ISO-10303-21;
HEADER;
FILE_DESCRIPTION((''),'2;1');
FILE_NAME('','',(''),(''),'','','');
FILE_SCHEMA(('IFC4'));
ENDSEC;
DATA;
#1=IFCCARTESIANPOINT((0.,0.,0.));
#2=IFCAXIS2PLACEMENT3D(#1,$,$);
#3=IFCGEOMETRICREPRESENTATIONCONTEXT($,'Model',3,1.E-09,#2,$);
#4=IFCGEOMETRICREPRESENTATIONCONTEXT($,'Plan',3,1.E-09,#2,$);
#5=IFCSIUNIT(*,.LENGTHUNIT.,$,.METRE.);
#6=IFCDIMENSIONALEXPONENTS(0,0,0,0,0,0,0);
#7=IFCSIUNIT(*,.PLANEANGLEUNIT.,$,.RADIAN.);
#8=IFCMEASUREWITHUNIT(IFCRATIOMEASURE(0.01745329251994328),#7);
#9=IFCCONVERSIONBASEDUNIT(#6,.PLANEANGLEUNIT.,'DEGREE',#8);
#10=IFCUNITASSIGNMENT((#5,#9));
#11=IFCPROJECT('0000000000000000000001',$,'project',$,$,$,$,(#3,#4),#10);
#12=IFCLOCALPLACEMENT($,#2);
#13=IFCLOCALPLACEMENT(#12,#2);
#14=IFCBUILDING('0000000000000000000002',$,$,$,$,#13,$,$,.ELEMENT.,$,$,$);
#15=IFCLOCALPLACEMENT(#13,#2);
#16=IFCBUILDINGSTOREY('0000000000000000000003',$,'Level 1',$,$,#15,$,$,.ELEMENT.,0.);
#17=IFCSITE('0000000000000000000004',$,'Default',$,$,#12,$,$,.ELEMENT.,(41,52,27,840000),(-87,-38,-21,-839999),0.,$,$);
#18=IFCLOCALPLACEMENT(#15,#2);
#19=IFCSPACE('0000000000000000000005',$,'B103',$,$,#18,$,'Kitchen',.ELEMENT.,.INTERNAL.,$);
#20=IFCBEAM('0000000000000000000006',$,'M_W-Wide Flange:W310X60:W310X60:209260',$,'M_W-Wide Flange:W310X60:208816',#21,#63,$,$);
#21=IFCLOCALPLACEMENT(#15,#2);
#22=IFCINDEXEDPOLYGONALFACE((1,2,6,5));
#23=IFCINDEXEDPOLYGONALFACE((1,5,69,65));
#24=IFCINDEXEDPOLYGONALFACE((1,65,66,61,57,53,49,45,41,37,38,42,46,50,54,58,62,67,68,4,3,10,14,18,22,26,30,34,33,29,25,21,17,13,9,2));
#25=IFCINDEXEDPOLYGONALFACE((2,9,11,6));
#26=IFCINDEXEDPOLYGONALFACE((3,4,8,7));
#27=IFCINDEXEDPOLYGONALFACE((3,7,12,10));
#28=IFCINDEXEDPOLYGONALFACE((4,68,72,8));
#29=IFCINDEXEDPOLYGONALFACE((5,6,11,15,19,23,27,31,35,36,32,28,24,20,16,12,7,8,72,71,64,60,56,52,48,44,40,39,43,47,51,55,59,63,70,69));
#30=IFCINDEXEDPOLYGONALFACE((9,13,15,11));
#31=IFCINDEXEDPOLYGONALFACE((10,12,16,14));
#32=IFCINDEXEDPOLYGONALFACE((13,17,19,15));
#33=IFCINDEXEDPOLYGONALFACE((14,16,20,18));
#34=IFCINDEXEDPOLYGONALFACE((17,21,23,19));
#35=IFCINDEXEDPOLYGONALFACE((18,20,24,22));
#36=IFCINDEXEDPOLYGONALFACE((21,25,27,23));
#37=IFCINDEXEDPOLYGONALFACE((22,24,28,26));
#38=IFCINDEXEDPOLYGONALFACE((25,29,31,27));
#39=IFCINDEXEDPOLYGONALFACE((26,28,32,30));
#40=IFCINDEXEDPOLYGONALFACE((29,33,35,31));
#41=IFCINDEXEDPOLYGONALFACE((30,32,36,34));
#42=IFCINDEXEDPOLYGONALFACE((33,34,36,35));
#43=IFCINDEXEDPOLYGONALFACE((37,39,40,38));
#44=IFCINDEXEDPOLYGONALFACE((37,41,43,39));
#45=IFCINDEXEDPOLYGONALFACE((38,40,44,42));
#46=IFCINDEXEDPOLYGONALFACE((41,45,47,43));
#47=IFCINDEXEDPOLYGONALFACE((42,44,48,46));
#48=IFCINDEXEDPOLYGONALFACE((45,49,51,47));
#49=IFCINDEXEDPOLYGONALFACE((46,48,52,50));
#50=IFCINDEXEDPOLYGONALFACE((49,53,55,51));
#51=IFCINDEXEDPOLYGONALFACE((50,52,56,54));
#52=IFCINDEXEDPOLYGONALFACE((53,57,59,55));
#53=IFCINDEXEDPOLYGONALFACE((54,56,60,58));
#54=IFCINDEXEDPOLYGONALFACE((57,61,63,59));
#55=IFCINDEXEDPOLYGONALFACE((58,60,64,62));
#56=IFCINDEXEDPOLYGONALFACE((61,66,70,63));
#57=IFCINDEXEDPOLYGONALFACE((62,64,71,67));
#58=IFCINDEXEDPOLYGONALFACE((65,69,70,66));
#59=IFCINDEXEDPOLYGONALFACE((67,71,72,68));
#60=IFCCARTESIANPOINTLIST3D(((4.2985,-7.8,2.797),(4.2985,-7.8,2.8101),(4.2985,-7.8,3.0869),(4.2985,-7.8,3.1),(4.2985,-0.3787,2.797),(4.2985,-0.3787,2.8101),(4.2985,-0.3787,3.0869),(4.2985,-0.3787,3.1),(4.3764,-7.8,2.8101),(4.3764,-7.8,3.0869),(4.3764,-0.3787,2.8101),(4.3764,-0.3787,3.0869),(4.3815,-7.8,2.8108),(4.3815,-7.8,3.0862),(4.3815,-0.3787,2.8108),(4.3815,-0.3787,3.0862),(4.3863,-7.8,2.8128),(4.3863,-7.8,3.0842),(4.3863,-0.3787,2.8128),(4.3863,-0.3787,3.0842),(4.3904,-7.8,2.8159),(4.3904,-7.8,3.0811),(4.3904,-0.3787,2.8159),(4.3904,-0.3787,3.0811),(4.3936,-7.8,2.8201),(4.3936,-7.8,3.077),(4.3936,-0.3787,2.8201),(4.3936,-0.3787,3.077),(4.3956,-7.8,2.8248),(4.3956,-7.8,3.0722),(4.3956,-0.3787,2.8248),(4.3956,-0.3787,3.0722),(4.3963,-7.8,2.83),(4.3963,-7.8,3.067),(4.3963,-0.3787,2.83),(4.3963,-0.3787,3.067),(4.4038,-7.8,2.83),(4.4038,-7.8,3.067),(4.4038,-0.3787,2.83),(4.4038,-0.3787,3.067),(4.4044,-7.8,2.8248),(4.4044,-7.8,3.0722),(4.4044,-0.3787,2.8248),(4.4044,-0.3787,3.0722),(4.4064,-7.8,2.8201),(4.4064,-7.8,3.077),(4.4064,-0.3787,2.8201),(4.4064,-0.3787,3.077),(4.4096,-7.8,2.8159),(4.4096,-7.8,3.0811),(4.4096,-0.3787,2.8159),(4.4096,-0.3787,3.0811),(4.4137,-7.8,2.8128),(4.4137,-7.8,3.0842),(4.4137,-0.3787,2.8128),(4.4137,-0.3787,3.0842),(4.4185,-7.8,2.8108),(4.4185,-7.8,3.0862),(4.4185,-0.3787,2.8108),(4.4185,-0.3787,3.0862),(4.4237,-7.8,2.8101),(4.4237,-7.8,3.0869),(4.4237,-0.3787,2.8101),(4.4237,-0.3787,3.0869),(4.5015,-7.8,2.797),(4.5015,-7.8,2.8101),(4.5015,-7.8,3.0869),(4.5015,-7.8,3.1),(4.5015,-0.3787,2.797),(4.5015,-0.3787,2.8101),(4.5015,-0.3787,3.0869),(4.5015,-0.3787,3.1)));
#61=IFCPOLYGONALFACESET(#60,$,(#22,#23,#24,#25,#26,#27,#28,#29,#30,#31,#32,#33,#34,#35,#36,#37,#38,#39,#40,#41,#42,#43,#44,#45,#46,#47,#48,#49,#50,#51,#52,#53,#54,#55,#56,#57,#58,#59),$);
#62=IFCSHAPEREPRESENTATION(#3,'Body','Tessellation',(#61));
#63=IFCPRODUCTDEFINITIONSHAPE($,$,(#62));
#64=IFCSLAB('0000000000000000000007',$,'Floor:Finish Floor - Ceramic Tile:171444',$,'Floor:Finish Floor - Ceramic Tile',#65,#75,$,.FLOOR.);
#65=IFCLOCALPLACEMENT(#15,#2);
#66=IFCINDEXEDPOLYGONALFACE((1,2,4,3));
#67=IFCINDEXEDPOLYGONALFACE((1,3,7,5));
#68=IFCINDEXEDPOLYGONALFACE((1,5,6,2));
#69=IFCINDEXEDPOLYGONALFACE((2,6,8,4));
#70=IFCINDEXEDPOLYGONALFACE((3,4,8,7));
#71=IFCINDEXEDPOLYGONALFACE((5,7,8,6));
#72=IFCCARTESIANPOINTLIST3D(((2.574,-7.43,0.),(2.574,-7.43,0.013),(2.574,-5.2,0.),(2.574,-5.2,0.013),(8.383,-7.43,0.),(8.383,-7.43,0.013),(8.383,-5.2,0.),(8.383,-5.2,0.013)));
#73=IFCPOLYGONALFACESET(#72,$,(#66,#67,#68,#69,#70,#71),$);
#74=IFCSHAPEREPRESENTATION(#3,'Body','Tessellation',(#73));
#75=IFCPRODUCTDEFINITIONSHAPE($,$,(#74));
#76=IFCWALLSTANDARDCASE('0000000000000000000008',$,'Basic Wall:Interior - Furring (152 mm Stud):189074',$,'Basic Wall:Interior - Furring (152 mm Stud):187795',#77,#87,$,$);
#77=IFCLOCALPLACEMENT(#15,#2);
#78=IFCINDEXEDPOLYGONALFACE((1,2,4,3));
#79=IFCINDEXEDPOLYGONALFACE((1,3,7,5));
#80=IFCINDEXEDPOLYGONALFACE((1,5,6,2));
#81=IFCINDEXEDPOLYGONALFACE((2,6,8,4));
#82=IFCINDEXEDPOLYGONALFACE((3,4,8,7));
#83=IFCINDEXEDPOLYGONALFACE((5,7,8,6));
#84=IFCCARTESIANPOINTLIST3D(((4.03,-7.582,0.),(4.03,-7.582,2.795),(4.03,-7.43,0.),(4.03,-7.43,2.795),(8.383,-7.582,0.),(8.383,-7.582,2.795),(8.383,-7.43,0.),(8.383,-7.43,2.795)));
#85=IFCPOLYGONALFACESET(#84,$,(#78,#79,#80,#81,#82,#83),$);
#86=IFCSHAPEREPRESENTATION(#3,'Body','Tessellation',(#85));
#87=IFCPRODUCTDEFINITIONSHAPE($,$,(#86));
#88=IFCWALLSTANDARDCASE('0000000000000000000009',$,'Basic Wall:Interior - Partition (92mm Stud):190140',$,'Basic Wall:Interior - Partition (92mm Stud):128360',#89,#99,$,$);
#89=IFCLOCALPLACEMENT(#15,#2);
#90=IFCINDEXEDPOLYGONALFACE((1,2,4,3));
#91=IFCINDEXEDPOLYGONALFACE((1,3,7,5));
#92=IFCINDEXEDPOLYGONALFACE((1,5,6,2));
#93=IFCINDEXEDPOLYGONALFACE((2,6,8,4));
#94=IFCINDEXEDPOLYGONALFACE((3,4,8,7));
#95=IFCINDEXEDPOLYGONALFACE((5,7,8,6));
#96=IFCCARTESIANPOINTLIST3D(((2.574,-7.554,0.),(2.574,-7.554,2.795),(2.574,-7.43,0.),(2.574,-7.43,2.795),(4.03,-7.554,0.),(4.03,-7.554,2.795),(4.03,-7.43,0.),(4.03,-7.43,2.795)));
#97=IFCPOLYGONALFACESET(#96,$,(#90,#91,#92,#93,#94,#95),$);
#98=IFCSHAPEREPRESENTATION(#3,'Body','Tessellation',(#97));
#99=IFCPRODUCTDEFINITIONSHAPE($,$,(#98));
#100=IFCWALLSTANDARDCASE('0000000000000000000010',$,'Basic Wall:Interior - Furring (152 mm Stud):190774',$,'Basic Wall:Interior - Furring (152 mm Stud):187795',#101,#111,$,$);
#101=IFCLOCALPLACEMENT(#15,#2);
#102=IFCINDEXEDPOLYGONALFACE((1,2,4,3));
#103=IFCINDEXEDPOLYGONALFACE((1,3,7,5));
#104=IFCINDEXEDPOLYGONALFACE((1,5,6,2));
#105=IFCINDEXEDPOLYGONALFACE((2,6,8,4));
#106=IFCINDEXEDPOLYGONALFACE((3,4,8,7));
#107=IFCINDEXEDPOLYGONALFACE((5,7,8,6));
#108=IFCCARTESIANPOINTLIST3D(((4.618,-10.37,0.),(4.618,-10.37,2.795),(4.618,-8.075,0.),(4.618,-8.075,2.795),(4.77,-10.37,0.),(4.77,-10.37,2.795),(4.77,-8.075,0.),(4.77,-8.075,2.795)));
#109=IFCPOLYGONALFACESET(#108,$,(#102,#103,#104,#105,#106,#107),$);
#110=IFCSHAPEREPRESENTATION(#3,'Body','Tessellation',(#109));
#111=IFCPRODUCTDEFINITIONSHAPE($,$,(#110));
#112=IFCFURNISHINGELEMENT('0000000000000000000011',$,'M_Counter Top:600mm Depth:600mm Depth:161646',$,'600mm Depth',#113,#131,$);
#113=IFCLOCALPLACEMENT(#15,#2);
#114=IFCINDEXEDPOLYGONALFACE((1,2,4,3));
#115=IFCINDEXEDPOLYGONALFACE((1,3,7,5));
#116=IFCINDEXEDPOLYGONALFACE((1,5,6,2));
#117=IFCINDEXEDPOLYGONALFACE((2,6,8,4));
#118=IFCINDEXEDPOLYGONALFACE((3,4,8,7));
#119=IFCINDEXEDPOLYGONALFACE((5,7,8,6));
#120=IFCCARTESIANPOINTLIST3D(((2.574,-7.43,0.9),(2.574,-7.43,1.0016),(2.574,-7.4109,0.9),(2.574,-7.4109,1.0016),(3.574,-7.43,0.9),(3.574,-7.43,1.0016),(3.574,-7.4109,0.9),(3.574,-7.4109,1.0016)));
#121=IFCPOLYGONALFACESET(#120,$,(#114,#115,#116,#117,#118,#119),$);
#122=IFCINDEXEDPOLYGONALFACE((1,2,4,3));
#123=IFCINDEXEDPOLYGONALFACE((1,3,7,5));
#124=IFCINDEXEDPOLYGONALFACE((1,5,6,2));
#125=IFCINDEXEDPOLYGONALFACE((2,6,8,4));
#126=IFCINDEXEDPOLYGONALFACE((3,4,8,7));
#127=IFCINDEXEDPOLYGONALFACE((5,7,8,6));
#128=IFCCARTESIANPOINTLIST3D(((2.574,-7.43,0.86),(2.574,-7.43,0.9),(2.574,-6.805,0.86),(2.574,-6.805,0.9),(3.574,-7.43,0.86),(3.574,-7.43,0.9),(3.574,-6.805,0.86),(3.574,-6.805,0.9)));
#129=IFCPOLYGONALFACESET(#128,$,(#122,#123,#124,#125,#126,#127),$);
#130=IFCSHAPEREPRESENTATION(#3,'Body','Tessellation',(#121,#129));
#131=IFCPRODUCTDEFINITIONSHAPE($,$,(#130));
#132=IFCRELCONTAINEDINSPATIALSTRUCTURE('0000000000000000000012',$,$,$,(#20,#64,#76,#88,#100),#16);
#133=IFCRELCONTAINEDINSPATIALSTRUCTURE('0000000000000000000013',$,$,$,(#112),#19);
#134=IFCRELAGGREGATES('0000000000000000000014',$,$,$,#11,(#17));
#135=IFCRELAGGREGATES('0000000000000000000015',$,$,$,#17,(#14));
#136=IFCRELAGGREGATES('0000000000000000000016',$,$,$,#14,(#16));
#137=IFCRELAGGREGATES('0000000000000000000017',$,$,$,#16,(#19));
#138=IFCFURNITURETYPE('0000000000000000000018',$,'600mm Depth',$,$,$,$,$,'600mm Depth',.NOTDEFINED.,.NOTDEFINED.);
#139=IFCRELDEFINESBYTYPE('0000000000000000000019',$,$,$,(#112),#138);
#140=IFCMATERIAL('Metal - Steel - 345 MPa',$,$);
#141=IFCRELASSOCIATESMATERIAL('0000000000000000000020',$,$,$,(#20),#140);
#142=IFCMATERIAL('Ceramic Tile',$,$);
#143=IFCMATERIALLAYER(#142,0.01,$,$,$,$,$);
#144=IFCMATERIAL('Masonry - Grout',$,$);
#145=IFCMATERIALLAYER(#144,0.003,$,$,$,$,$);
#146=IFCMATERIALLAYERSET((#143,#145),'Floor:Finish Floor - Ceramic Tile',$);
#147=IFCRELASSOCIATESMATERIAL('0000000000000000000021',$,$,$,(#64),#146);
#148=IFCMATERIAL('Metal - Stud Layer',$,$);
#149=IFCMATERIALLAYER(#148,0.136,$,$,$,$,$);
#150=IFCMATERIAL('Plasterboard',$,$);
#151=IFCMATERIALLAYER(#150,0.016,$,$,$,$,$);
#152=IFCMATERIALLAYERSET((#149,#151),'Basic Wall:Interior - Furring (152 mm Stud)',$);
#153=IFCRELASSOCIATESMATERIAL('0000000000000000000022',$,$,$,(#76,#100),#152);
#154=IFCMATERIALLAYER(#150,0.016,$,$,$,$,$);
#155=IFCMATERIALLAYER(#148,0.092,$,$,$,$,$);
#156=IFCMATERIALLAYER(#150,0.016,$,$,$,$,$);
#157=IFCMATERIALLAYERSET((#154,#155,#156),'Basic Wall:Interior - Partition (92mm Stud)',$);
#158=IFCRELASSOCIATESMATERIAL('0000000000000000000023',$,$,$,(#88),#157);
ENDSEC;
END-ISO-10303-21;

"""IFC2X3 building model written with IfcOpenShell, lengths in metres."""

from ifc_helpers import new_model, entity, si_unit, converted_unit, frame, frame_2d, origin, origin_2d_with_axis, place, context, project, spatial, polyline, circle_curve, parameter, trimmed, segment, composite_curve, rectangle, outline, extrude, clip, bounded_halfspace, source, transform, mapped, material, layer, layer_set, layer_usage, type_object, type_shapes, element, save


model = new_model("IFC2X3")

# Units and contexts
model_context = context("Model", 3, precision=1e-09, world=origin())
plan_context = context("Plan", 3, precision=1e-09, world=origin())
ifc_project = project(units=[si_unit("LENGTHUNIT", "METRE"), converted_unit("PLANEANGLEUNIT", "DEGREE", entity("IfcRatioMeasure", 0.01745329251994328), si_unit("PLANEANGLEUNIT", "RADIAN"), dimensions=[0, 0, 0, 0, 0, 0, 0])], contexts=[model_context, plan_context])

# Site, building, storey
site_placement = place(None, origin())
site = spatial("IfcSite", under=ifc_project, at=site_placement, Name="Default", CompositionType="ELEMENT", RefLatitude=(41, 52, 27, 840000), RefLongitude=(-87, -38, -21, -839999), RefElevation=0.0)
building_placement = place(site_placement, origin())
building = spatial("IfcBuilding", under=site, at=building_placement, CompositionType="ELEMENT")
storey_placement = place(building_placement, origin())
storey = spatial("IfcBuildingStorey", under=building, at=storey_placement, Name="Level 1", CompositionType="ELEMENT", Elevation=0.0)

# Beam
ifc_material_1 = material(Name="Metal - Steel - 345 MPa")
beam_placement = place(storey_placement, frame((4.4, -7.8, 3.1)))
element("IfcBeam", 1, at=beam_placement, inside=storey, material=ifc_material_1, Name="M_W-Wide Flange:W310X60:W310X60:209260", ObjectType="M_W-Wide Flange:W310X60:208816", context=model_context, shape_type="SweptSolid", body=[
    extrude(outline(composite_curve([segment(polyline([(-0.1015, -0.1384), (-0.1015, -0.1515)]), True, "CONTINUOUS"), segment(polyline([(-0.1015, -0.1515), (0.1015, -0.1515)]), True, "CONTINUOUS"), segment(polyline([(0.1015, -0.1515), (0.1015, -0.1384)]), True, "CONTINUOUS"), segment(polyline([(0.1015, -0.1384), (0.0236, -0.1384)]), True, "CONTINUOUS"), segment(trimmed(circle_curve(frame_2d((0.0236, -0.1185), x_axis=(1.0, 0.0)), 0.0199), [parameter(180.0)], [parameter(270.0)], True, "PARAMETER"), False, "CONTINUOUS"), segment(polyline([(0.0037, -0.1185), (0.0037, 0.1185)]), True, "CONTINUOUS"), segment(trimmed(circle_curve(frame_2d((0.0236, 0.1185), x_axis=(1.0, 0.0)), 0.0199), [parameter(90.0)], [parameter(180.0)], True, "PARAMETER"), False, "CONTINUOUS"), segment(polyline([(0.0236, 0.1384), (0.1015, 0.1384)]), True, "CONTINUOUS"), segment(polyline([(0.1015, 0.1384), (0.1015, 0.1515)]), True, "CONTINUOUS"), segment(polyline([(0.1015, 0.1515), (-0.1015, 0.1515)]), True, "CONTINUOUS"), segment(polyline([(-0.1015, 0.1515), (-0.1015, 0.1384)]), True, "CONTINUOUS"), segment(polyline([(-0.1015, 0.1384), (-0.0237, 0.1384)]), True, "CONTINUOUS"), segment(trimmed(circle_curve(frame_2d((-0.0237, 0.1185), x_axis=(1.0, 0.0)), 0.0199), [parameter(360.0)], [parameter(90.0)], True, "PARAMETER"), False, "CONTINUOUS"), segment(polyline([(-0.0038, 0.1185), (-0.0038, -0.1185)]), True, "CONTINUOUS"), segment(trimmed(circle_curve(frame_2d((-0.0237, -0.1185), x_axis=(1.0, 0.0)), 0.0199), [parameter(270.0)], [parameter(0.0)], True, "PARAMETER"), False, "CONTINUOUS"), segment(polyline([(-0.0237, -0.1384), (-0.1015, -0.1384)]), True, "CONTINUOUS")], self_intersect=False)), frame((0.0, 0.0, -0.1515), z_axis=(0.0, -1.0, 0.0), x_axis=(1.0, 0.0, 0.0)), (0.0, 0.0, -1.0), 7.4213),
])

# Slab
ifc_material_2 = material(Name="Ceramic Tile")
ifc_layer_1 = layer(ifc_material_2, 0.01)
ifc_material_3 = material(Name="Masonry - Grout")
ifc_layer_2 = layer(ifc_material_3, 0.003)
ifc_layer_set_1 = layer_set([ifc_layer_1, ifc_layer_2], Name="Floor:Finish Floor - Ceramic Tile")
ifc_layer_usage_1 = layer_usage(ifc_layer_set_1, "AXIS3", "POSITIVE", 0.0)
slab_placement = place(storey_placement, frame((2.574, -7.43, 0.0)))
element("IfcSlab", 2, at=slab_placement, inside=storey, material=ifc_layer_usage_1, Name="Floor:Finish Floor - Ceramic Tile:171444", ObjectType="Floor:Finish Floor - Ceramic Tile", PredefinedType="FLOOR", context=model_context, shape_type="SweptSolid", body=[
    extrude(rectangle(XDim=5.809, YDim=2.23, at=frame_2d((0.0, 0.0), x_axis=(-1.0, 0.0))), frame((2.9045, 1.115, 0.013), z_axis=(0.0, 0.0, -1.0), x_axis=(-1.0, 0.0, 0.0)), (0.0, 0.0, 1.0), 0.013),
])

# Walls
ifc_material_4 = material(Name="Plasterboard")
ifc_material_5 = material(Name="Metal - Stud Layer")
ifc_layer_3 = layer(ifc_material_5, 0.136)
ifc_layer_4 = layer(ifc_material_4, 0.016)
ifc_layer_set_2 = layer_set([ifc_layer_3, ifc_layer_4], Name="Basic Wall:Interior - Furring (152 mm Stud)")
ifc_layer_usage_2 = layer_usage(ifc_layer_set_2, "AXIS2", "NEGATIVE", 0.076)
wall_1_placement = place(storey_placement, frame((8.383, -7.506, 0.0), z_axis=(0.0, 0.0, 1.0), x_axis=(-1.0, 0.0, 0.0)))
element("IfcWallStandardCase", 3, at=wall_1_placement, inside=storey, material=ifc_layer_usage_2, Name="Basic Wall:Interior - Furring (152 mm Stud):189074", ObjectType="Basic Wall:Interior - Furring (152 mm Stud):187795", context=model_context, shape_type="Clipping", body=[
    clip(extrude(rectangle(XDim=4.353, YDim=0.152, at=frame_2d((2.1765, 0.0), x_axis=(-1.0, 0.0))), origin(), (0.0, 0.0, 1.0), 2.795), bounded_halfspace(frame((0.0, -0.076, 2.795), z_axis=(0.0, 0.0, -1.0), x_axis=(0.0, 1.0, 0.0)), True, frame((0.0, -0.076, 2.795)), polyline([(0.0, 0.0), (3.708, 0.0), (3.708, 0.152), (0.0, 0.152), (0.0, 0.0)]))),
])
ifc_layer_5 = layer(ifc_material_4, 0.016)
ifc_layer_6 = layer(ifc_material_5, 0.092)
ifc_layer_7 = layer(ifc_material_4, 0.016)
ifc_layer_set_3 = layer_set([ifc_layer_5, ifc_layer_6, ifc_layer_7], Name="Basic Wall:Interior - Partition (92mm Stud)")
ifc_layer_usage_3 = layer_usage(ifc_layer_set_3, "AXIS2", "NEGATIVE", 0.062)
wall_2_placement = place(storey_placement, frame((4.03, -7.492, 0.0), z_axis=(0.0, 0.0, 1.0), x_axis=(-1.0, 0.0, 0.0)))
element("IfcWallStandardCase", 4, at=wall_2_placement, inside=storey, material=ifc_layer_usage_3, Name="Basic Wall:Interior - Partition (92mm Stud):190140", ObjectType="Basic Wall:Interior - Partition (92mm Stud):128360", context=model_context, shape_type="SweptSolid", body=[
    extrude(rectangle(XDim=1.456, YDim=0.124, at=frame_2d((0.728, 0.0), x_axis=(-1.0, 0.0))), origin(), (0.0, 0.0, 1.0), 2.795),
])
ifc_layer_usage_4 = layer_usage(ifc_layer_set_2, "AXIS2", "POSITIVE", -0.076)
wall_3_placement = place(storey_placement, frame((4.694, -8.075, 0.0), z_axis=(0.0, 0.0, 1.0), x_axis=(0.0, -1.0, 0.0)))
element("IfcWallStandardCase", 5, at=wall_3_placement, inside=storey, material=ifc_layer_usage_4, Name="Basic Wall:Interior - Furring (152 mm Stud):190774", ObjectType="Basic Wall:Interior - Furring (152 mm Stud):187795", context=model_context, shape_type="SweptSolid", body=[
    extrude(rectangle(XDim=2.295, YDim=0.152, at=frame_2d((1.1475, 0.0), x_axis=(-1.0, 0.0))), origin(), (0.0, 0.0, 1.0), 2.795),
])

# Shared definitions
space_placement = place(storey_placement, origin())
space = spatial("IfcSpace", under=storey, at=space_placement, Name="B103", LongName="Kitchen", CompositionType="ELEMENT", InteriorOrExteriorSpace="INTERNAL")

# Furnishing element
furniture_type_1 = type_object("IfcFurnitureType", Name="600mm Depth", ElementType="600mm Depth", AssemblyPlace="NOTDEFINED")
shared_shape_1 = source(origin(), model_context, "Body", "SweptSolid", [
    extrude(rectangle(XDim=0.0191, YDim=1.0, at=origin_2d_with_axis()), frame((-0.7005, -0.0095, 0.9), z_axis=(0.0, 0.0, 1.0), x_axis=(0.0, -1.0, 0.0)), (0.0, 0.0, 1.0), 0.1016),
    extrude(rectangle(XDim=1.0, YDim=0.625, at=origin_2d_with_axis()), frame((-0.7005, -0.3125, 0.86), z_axis=(0.0, 0.0, 1.0), x_axis=(-1.0, 0.0, 0.0)), (0.0, 0.0, 1.0), 0.04),
])
type_shapes(furniture_type_1, [shared_shape_1])
furnishing_1_placement = place(space_placement, frame((2.3735, -7.43, 0.0), z_axis=(0.0, 0.0, 1.0), x_axis=(-1.0, 0.0, 0.0)))
element("IfcFurnishingElement", 6, at=furnishing_1_placement, inside=space, type_object=furniture_type_1, Name="M_Counter Top:600mm Depth:600mm Depth:161646", ObjectType="600mm Depth", context=model_context, shape_type="MappedRepresentation", body=[
    mapped(shared_shape_1, transform((0.0, 0.0, 0.0), scale=1.0)),
])

save(model, "model.ifc")
